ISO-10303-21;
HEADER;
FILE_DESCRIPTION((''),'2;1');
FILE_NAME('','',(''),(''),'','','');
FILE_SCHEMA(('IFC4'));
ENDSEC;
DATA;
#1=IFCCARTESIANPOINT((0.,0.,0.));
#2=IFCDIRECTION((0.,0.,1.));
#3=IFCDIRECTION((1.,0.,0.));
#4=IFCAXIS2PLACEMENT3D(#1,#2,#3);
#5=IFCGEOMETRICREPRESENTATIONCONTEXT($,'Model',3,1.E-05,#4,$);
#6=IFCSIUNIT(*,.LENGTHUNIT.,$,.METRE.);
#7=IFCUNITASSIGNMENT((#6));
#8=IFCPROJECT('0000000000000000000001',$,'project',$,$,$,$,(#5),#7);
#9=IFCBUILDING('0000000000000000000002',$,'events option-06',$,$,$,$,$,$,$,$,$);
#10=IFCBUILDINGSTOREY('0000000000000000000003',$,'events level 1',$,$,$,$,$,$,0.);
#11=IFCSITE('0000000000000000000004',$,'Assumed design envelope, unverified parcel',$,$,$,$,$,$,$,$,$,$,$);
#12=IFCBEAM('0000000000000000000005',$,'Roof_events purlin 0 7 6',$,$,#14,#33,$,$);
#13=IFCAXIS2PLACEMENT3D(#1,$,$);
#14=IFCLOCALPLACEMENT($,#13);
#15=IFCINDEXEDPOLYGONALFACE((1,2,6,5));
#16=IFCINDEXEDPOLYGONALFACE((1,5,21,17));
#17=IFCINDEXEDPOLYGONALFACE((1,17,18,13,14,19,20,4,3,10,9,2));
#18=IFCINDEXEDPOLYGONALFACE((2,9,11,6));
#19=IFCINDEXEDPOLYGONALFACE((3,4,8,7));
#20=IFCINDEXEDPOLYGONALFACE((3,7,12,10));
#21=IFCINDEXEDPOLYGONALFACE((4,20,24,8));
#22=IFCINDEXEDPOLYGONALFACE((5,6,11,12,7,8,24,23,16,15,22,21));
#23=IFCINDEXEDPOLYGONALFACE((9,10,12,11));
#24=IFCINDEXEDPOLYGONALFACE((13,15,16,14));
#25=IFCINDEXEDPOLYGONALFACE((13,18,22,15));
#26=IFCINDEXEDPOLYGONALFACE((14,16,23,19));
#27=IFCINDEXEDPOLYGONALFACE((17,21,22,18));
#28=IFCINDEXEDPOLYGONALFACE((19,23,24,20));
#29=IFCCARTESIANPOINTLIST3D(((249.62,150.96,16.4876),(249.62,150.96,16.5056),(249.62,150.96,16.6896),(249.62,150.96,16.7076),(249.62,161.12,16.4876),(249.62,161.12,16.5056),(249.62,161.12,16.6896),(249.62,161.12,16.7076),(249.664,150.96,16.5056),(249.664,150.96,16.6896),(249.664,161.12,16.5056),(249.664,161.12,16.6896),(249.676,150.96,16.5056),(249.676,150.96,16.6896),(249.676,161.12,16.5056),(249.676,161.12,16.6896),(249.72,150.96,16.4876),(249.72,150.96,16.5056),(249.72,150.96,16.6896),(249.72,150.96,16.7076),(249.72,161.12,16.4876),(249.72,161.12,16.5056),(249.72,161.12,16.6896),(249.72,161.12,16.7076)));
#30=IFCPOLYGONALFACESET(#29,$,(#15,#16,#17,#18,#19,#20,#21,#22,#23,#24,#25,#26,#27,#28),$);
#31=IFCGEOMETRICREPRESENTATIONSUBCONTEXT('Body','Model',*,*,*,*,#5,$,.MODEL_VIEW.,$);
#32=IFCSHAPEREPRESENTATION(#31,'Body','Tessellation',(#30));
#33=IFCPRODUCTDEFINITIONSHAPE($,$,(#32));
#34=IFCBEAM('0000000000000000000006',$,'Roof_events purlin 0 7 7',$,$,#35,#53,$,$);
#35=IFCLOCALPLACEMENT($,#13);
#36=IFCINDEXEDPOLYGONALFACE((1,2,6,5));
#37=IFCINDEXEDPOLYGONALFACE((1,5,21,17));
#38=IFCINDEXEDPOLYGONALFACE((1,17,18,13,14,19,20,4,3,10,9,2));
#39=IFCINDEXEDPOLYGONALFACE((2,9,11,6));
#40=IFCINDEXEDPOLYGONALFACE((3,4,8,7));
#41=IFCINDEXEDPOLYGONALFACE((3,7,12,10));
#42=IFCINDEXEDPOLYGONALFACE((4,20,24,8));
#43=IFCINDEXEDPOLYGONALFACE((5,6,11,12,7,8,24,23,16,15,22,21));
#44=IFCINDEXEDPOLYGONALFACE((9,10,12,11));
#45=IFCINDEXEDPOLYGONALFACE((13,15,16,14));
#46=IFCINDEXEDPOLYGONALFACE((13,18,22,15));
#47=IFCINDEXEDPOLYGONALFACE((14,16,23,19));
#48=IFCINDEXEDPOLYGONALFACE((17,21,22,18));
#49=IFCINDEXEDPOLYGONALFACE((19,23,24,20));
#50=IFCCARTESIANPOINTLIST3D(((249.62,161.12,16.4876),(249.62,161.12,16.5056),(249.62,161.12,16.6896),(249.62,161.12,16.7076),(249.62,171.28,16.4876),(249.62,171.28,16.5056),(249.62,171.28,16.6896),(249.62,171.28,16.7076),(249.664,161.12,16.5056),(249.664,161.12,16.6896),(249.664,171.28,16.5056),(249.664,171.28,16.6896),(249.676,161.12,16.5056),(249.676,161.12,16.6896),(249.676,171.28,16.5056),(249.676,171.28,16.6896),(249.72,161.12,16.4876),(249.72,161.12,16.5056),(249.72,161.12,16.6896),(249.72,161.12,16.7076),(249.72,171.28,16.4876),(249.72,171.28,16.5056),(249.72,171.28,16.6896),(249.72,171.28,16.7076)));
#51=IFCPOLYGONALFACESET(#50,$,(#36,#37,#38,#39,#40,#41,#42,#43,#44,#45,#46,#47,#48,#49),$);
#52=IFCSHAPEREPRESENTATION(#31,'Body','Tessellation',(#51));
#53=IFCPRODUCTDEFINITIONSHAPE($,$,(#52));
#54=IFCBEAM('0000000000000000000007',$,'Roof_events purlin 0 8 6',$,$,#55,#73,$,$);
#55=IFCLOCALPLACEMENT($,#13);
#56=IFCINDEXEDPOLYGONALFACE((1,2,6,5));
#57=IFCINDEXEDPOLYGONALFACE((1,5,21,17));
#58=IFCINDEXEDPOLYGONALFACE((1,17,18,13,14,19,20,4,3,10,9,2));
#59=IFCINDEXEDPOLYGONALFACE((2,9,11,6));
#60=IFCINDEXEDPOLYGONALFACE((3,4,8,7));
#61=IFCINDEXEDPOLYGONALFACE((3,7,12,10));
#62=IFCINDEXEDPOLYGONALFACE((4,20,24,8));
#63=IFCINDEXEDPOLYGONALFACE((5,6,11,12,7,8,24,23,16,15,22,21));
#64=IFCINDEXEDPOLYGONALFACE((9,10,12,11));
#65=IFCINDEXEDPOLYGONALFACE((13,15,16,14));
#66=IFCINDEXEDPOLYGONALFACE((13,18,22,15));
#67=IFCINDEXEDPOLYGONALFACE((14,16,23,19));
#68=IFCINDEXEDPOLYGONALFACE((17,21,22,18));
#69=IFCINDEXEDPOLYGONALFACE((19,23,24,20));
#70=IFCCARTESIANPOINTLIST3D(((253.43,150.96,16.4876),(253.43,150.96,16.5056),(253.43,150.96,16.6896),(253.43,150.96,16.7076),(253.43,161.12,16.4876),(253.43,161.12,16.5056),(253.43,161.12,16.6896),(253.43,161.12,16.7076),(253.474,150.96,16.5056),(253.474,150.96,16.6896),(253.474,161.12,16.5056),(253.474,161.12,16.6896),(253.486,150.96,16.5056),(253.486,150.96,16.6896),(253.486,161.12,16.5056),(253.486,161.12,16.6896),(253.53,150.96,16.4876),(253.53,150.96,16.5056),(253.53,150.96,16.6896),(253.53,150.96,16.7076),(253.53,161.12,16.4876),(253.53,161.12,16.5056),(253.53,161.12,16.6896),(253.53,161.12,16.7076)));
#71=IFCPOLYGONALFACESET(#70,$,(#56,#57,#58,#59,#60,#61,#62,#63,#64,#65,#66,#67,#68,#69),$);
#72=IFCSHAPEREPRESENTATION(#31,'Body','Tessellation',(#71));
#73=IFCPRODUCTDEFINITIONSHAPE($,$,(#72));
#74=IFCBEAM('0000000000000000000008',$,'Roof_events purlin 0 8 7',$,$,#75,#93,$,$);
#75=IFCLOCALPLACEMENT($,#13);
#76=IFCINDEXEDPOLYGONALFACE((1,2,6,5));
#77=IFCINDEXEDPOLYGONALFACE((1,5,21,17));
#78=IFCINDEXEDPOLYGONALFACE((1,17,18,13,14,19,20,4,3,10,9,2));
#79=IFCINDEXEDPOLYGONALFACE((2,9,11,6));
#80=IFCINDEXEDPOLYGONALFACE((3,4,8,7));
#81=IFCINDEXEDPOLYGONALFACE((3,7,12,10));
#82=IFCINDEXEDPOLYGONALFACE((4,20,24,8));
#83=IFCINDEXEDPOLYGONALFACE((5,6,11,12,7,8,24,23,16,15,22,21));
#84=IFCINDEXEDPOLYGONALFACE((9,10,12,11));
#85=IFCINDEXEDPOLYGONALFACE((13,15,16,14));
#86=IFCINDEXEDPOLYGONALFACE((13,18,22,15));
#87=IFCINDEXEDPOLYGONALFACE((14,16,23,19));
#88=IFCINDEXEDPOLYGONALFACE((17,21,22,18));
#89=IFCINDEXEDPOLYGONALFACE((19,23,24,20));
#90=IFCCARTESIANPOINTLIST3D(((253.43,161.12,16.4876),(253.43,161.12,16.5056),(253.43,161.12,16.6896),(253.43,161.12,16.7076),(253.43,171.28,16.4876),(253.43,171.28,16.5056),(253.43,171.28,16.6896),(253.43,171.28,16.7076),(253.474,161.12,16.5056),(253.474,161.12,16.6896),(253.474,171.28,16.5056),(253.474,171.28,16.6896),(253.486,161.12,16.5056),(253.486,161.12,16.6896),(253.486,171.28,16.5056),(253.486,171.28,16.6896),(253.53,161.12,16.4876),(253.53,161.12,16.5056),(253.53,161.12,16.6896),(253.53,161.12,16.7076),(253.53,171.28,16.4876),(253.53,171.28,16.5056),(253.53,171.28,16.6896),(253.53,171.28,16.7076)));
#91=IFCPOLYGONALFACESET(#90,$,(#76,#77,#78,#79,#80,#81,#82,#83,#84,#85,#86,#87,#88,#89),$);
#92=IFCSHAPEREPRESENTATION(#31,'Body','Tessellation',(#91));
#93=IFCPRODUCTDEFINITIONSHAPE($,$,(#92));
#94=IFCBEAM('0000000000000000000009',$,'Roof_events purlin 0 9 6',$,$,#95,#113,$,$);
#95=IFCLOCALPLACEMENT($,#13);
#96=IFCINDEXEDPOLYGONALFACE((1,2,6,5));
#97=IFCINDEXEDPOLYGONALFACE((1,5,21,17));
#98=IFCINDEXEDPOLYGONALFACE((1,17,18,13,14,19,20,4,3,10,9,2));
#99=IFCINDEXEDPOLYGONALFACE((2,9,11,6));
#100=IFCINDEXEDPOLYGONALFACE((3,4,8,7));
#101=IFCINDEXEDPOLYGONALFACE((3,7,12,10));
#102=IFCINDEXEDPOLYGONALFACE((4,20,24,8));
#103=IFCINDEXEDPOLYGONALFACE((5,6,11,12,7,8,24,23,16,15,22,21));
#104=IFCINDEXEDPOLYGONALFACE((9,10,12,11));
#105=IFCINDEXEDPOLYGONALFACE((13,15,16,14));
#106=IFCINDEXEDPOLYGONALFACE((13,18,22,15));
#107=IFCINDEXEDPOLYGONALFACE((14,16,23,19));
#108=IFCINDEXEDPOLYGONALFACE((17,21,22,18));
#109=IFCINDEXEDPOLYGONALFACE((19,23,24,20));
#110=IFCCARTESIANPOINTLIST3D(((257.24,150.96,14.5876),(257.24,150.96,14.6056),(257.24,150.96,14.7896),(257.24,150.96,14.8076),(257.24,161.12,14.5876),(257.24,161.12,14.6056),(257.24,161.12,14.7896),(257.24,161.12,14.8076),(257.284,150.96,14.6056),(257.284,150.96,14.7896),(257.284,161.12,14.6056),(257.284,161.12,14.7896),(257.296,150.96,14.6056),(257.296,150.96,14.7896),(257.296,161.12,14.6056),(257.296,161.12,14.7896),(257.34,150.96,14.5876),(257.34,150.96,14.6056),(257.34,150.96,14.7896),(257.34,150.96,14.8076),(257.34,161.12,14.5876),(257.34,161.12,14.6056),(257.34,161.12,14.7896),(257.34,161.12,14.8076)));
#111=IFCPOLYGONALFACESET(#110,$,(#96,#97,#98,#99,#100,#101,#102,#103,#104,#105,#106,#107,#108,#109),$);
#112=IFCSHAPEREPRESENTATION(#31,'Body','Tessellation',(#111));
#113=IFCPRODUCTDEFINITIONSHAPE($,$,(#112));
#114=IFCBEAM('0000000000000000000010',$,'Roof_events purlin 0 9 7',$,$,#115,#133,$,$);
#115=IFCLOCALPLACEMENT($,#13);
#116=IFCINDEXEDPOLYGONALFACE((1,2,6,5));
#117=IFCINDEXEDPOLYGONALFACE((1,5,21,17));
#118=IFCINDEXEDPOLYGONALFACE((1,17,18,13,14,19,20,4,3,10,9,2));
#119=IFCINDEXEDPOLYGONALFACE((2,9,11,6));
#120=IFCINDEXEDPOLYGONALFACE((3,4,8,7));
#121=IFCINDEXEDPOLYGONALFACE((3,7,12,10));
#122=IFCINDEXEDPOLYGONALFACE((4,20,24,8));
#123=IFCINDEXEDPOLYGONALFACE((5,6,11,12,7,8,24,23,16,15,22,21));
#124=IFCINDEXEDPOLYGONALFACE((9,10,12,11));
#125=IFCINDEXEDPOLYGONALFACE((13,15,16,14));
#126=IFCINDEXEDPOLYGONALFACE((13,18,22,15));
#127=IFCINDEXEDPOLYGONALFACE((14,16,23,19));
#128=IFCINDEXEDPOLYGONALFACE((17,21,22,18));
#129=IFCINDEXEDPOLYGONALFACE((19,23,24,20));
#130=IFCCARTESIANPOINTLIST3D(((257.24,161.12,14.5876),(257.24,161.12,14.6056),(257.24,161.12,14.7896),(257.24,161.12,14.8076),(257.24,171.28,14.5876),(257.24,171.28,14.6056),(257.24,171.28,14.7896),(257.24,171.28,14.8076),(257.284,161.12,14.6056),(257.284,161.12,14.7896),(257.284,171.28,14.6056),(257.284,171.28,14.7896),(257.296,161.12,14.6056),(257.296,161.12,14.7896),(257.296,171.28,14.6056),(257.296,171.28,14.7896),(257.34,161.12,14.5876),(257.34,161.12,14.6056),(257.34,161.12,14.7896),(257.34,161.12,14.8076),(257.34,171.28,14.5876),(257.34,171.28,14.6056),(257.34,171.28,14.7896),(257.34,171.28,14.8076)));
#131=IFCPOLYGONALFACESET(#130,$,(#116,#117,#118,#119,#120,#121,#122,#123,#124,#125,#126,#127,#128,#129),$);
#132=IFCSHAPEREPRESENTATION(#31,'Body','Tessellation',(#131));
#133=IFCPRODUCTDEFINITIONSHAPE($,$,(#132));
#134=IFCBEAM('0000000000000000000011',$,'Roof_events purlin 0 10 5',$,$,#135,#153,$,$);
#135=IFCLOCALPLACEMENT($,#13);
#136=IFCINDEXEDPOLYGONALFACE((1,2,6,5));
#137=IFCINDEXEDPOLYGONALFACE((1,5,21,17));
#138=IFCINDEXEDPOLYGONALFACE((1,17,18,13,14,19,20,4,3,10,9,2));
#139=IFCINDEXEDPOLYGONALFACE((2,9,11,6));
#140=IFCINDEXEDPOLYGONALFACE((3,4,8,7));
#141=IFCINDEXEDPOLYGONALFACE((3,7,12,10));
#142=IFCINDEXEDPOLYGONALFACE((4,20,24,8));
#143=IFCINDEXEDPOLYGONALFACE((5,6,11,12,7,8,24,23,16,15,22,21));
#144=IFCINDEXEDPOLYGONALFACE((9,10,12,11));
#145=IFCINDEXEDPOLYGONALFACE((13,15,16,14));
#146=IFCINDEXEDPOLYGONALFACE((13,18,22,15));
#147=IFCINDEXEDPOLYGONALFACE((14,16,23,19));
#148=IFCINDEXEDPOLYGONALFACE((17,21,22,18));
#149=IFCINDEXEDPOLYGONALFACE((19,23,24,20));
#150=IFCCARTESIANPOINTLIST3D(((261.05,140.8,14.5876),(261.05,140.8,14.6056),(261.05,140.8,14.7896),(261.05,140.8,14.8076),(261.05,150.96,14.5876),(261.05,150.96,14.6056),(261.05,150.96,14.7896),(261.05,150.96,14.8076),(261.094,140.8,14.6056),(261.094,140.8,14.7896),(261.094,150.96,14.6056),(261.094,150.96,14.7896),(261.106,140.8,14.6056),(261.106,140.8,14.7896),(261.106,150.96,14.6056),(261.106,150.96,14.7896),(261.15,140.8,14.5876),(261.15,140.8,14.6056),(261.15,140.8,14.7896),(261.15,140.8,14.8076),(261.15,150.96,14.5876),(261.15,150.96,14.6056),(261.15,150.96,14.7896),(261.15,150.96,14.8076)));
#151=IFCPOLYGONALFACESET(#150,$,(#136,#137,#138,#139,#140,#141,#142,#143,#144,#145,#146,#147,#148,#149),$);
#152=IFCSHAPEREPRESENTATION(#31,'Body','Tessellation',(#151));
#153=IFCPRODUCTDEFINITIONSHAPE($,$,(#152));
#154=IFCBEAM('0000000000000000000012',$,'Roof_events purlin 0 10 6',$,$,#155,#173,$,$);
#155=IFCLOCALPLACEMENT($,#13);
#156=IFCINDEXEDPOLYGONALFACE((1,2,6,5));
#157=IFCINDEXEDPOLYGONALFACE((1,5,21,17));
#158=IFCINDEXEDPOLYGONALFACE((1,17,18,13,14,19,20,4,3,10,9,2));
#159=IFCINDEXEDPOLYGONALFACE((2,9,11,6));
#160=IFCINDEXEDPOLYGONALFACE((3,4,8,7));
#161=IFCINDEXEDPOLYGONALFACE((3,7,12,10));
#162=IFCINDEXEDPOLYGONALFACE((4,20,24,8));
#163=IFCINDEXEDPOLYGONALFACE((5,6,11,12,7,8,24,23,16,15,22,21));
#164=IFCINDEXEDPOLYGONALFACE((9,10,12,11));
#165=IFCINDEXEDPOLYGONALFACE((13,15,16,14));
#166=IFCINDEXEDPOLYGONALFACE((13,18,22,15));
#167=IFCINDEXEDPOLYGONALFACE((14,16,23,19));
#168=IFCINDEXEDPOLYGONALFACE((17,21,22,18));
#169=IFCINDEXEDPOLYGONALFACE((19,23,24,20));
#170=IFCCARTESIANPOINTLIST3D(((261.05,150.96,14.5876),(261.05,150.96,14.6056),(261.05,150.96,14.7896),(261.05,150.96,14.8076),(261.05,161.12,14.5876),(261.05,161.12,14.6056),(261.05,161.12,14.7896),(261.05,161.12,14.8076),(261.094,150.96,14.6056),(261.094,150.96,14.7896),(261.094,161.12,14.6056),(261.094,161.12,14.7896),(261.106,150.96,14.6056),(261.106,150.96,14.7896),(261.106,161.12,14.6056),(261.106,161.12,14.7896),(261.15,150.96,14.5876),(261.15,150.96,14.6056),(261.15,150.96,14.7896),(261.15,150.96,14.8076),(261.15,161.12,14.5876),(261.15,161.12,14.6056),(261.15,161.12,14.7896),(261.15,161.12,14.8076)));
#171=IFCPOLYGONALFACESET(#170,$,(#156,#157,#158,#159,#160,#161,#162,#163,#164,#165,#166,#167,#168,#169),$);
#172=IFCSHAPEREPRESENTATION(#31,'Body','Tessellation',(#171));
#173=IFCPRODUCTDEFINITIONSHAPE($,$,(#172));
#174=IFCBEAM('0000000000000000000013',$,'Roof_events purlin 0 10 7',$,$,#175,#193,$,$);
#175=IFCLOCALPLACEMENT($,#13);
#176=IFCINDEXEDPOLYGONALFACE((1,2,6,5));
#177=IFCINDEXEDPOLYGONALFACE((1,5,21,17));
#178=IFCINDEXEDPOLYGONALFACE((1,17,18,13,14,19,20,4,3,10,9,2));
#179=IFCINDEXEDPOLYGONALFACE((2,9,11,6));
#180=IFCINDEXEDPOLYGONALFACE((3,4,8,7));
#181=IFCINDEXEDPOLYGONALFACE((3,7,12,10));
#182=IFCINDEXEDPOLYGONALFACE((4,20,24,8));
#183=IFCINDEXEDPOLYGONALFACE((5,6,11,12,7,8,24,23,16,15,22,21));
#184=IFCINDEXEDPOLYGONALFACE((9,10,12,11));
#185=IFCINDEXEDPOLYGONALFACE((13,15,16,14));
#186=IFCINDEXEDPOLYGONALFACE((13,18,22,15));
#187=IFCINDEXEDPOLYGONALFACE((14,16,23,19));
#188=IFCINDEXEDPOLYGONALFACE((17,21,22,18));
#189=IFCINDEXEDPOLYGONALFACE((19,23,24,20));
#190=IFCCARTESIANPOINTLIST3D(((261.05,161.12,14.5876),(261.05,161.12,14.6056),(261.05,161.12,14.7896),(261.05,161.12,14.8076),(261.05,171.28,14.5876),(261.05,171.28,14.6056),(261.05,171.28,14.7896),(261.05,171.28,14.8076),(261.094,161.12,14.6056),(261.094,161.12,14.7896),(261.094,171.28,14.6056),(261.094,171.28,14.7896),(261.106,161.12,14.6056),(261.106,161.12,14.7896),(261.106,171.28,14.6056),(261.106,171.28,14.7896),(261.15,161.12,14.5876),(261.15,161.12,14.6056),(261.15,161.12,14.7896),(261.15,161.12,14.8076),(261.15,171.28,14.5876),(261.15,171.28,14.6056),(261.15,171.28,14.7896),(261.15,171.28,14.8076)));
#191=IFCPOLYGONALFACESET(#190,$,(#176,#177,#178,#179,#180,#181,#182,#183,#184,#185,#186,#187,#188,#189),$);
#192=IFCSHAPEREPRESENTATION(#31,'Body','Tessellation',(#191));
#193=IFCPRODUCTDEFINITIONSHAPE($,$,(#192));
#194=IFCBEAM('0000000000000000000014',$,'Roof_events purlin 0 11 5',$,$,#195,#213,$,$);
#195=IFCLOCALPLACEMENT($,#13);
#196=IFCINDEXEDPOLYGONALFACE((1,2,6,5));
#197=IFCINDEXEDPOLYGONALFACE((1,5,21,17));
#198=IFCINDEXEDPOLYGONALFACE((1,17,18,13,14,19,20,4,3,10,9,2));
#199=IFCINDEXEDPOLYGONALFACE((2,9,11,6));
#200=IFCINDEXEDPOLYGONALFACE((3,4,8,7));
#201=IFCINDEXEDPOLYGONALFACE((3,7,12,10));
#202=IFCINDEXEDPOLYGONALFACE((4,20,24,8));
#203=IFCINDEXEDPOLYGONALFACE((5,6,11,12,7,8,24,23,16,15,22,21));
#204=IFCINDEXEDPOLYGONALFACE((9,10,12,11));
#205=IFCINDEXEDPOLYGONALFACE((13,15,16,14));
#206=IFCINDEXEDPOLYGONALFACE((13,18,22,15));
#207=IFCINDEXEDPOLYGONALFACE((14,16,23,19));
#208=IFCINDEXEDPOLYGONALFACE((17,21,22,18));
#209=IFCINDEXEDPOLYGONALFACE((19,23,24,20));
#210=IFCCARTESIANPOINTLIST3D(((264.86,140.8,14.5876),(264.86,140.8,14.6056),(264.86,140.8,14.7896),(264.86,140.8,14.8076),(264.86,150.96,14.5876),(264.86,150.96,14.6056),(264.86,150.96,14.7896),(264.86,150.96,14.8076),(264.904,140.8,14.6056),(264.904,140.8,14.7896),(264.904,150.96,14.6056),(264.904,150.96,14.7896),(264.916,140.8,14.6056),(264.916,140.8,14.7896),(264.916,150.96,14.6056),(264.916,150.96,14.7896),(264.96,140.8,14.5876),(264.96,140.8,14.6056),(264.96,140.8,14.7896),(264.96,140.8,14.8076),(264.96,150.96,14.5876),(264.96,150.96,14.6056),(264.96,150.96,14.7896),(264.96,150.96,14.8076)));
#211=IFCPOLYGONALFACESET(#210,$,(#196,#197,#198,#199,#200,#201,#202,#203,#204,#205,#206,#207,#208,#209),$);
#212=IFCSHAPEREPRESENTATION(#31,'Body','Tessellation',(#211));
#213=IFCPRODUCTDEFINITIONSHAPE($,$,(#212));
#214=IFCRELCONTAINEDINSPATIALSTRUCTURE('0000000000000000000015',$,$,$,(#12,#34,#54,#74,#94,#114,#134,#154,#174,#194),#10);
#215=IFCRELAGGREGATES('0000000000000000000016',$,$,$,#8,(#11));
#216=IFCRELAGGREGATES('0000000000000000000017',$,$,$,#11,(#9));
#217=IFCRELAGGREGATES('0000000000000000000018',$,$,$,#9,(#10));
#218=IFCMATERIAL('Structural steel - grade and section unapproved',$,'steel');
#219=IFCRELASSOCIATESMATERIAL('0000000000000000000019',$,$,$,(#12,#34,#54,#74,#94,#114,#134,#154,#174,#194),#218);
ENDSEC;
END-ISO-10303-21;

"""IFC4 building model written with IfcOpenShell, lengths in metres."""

from ifc_helpers import new_model, si_unit, frame, origin_with_axes, place, context, subcontext, project, spatial, i_section, extrude, material, element, save


model = new_model("IFC4")

# Units and contexts
model_context = context("Model", 3, precision=1e-05, world=origin_with_axes())
body_context = subcontext(model_context, "Body", "Model", "MODEL_VIEW")
ifc_project = project(units=[si_unit("LENGTHUNIT", "METRE")], contexts=[model_context])

# Site, building, storey
site = spatial("IfcSite", under=ifc_project, Name="Assumed design envelope, unverified parcel")
building = spatial("IfcBuilding", under=site, Name="events option-06")
storey = spatial("IfcBuildingStorey", under=building, Name="events level 1", Elevation=0.0)

# Beams
ifc_material = material(Name="Structural steel - grade and section unapproved", Category="steel")
beam_1_placement = place(None, frame((249.67, 150.96, 16.5976), z_axis=(0.0, 1.0, 0.0), x_axis=(-1.0, 0.0, 0.0)))
element("IfcBeam", 1, at=beam_1_placement, inside=storey, material=ifc_material, Name="Roof_events purlin 0 7 6", context=body_context, shape_type="SweptSolid", body=[
    extrude(i_section(OverallWidth=0.1, OverallDepth=0.22, WebThickness=0.012, FlangeThickness=0.018, FilletRadius=0.0), origin_with_axes(), (0.0, 0.0, 1.0), 10.16),
])
beam_2_placement = place(None, frame((249.67, 161.12, 16.5976), z_axis=(0.0, 1.0, 0.0), x_axis=(-1.0, 0.0, 0.0)))
element("IfcBeam", 2, at=beam_2_placement, inside=storey, material=ifc_material, Name="Roof_events purlin 0 7 7", context=body_context, shape_type="SweptSolid", body=[
    extrude(i_section(OverallWidth=0.1, OverallDepth=0.22, WebThickness=0.012, FlangeThickness=0.018, FilletRadius=0.0), origin_with_axes(), (0.0, 0.0, 1.0), 10.16),
])
beam_3_placement = place(None, frame((253.48, 150.96, 16.5976), z_axis=(0.0, 1.0, 0.0), x_axis=(-1.0, 0.0, 0.0)))
element("IfcBeam", 3, at=beam_3_placement, inside=storey, material=ifc_material, Name="Roof_events purlin 0 8 6", context=body_context, shape_type="SweptSolid", body=[
    extrude(i_section(OverallWidth=0.1, OverallDepth=0.22, WebThickness=0.012, FlangeThickness=0.018, FilletRadius=0.0), origin_with_axes(), (0.0, 0.0, 1.0), 10.16),
])
beam_4_placement = place(None, frame((253.48, 161.12, 16.5976), z_axis=(0.0, 1.0, 0.0), x_axis=(-1.0, 0.0, 0.0)))
element("IfcBeam", 4, at=beam_4_placement, inside=storey, material=ifc_material, Name="Roof_events purlin 0 8 7", context=body_context, shape_type="SweptSolid", body=[
    extrude(i_section(OverallWidth=0.1, OverallDepth=0.22, WebThickness=0.012, FlangeThickness=0.018, FilletRadius=0.0), origin_with_axes(), (0.0, 0.0, 1.0), 10.16),
])
beam_5_placement = place(None, frame((257.29, 150.96, 14.6976), z_axis=(0.0, 1.0, 0.0), x_axis=(-1.0, 0.0, 0.0)))
element("IfcBeam", 5, at=beam_5_placement, inside=storey, material=ifc_material, Name="Roof_events purlin 0 9 6", context=body_context, shape_type="SweptSolid", body=[
    extrude(i_section(OverallWidth=0.1, OverallDepth=0.22, WebThickness=0.012, FlangeThickness=0.018, FilletRadius=0.0), origin_with_axes(), (0.0, 0.0, 1.0), 10.16),
])
for number, where, z_axis, x_axis, name in (
    (6, (257.29, 161.12, 14.6976), (0.0, 1.0, 0.0), (-1.0, 0.0, 0.0), "Roof_events purlin 0 9 7"),
    (7, (261.1, 140.8, 14.6976), (0.0, 1.0, 0.0), (-1.0, 0.0, 0.0), "Roof_events purlin 0 10 5"),
):
    element("IfcBeam", number, at=place(None, frame(where, z_axis=z_axis, x_axis=x_axis)), inside=storey, material=ifc_material, Name=name, context=body_context, shape_type="SweptSolid", body=[
        extrude(i_section(OverallWidth=0.1, OverallDepth=0.22, WebThickness=0.012, FlangeThickness=0.018, FilletRadius=0.0), origin_with_axes(), (0.0, 0.0, 1.0), 10.16),
    ])
beam_6_placement = place(None, frame((261.1, 150.96, 14.6976), z_axis=(0.0, 1.0, 0.0), x_axis=(-1.0, 0.0, 0.0)))
element("IfcBeam", 8, at=beam_6_placement, inside=storey, material=ifc_material, Name="Roof_events purlin 0 10 6", context=body_context, shape_type="SweptSolid", body=[
    extrude(i_section(OverallWidth=0.1, OverallDepth=0.22, WebThickness=0.012, FlangeThickness=0.018, FilletRadius=0.0), origin_with_axes(), (0.0, 0.0, 1.0), 10.16),
])
for number, where, z_axis, x_axis, name in (
    (9, (261.1, 161.12, 14.6976), (0.0, 1.0, 0.0), (-1.0, 0.0, 0.0), "Roof_events purlin 0 10 7"),
    (10, (264.91, 140.8, 14.6976), (0.0, 1.0, 0.0), (-1.0, 0.0, 0.0), "Roof_events purlin 0 11 5"),
):
    element("IfcBeam", number, at=place(None, frame(where, z_axis=z_axis, x_axis=x_axis)), inside=storey, material=ifc_material, Name=name, context=body_context, shape_type="SweptSolid", body=[
        extrude(i_section(OverallWidth=0.1, OverallDepth=0.22, WebThickness=0.012, FlangeThickness=0.018, FilletRadius=0.0), origin_with_axes(), (0.0, 0.0, 1.0), 10.16),
    ])

save(model, "model.ifc")
